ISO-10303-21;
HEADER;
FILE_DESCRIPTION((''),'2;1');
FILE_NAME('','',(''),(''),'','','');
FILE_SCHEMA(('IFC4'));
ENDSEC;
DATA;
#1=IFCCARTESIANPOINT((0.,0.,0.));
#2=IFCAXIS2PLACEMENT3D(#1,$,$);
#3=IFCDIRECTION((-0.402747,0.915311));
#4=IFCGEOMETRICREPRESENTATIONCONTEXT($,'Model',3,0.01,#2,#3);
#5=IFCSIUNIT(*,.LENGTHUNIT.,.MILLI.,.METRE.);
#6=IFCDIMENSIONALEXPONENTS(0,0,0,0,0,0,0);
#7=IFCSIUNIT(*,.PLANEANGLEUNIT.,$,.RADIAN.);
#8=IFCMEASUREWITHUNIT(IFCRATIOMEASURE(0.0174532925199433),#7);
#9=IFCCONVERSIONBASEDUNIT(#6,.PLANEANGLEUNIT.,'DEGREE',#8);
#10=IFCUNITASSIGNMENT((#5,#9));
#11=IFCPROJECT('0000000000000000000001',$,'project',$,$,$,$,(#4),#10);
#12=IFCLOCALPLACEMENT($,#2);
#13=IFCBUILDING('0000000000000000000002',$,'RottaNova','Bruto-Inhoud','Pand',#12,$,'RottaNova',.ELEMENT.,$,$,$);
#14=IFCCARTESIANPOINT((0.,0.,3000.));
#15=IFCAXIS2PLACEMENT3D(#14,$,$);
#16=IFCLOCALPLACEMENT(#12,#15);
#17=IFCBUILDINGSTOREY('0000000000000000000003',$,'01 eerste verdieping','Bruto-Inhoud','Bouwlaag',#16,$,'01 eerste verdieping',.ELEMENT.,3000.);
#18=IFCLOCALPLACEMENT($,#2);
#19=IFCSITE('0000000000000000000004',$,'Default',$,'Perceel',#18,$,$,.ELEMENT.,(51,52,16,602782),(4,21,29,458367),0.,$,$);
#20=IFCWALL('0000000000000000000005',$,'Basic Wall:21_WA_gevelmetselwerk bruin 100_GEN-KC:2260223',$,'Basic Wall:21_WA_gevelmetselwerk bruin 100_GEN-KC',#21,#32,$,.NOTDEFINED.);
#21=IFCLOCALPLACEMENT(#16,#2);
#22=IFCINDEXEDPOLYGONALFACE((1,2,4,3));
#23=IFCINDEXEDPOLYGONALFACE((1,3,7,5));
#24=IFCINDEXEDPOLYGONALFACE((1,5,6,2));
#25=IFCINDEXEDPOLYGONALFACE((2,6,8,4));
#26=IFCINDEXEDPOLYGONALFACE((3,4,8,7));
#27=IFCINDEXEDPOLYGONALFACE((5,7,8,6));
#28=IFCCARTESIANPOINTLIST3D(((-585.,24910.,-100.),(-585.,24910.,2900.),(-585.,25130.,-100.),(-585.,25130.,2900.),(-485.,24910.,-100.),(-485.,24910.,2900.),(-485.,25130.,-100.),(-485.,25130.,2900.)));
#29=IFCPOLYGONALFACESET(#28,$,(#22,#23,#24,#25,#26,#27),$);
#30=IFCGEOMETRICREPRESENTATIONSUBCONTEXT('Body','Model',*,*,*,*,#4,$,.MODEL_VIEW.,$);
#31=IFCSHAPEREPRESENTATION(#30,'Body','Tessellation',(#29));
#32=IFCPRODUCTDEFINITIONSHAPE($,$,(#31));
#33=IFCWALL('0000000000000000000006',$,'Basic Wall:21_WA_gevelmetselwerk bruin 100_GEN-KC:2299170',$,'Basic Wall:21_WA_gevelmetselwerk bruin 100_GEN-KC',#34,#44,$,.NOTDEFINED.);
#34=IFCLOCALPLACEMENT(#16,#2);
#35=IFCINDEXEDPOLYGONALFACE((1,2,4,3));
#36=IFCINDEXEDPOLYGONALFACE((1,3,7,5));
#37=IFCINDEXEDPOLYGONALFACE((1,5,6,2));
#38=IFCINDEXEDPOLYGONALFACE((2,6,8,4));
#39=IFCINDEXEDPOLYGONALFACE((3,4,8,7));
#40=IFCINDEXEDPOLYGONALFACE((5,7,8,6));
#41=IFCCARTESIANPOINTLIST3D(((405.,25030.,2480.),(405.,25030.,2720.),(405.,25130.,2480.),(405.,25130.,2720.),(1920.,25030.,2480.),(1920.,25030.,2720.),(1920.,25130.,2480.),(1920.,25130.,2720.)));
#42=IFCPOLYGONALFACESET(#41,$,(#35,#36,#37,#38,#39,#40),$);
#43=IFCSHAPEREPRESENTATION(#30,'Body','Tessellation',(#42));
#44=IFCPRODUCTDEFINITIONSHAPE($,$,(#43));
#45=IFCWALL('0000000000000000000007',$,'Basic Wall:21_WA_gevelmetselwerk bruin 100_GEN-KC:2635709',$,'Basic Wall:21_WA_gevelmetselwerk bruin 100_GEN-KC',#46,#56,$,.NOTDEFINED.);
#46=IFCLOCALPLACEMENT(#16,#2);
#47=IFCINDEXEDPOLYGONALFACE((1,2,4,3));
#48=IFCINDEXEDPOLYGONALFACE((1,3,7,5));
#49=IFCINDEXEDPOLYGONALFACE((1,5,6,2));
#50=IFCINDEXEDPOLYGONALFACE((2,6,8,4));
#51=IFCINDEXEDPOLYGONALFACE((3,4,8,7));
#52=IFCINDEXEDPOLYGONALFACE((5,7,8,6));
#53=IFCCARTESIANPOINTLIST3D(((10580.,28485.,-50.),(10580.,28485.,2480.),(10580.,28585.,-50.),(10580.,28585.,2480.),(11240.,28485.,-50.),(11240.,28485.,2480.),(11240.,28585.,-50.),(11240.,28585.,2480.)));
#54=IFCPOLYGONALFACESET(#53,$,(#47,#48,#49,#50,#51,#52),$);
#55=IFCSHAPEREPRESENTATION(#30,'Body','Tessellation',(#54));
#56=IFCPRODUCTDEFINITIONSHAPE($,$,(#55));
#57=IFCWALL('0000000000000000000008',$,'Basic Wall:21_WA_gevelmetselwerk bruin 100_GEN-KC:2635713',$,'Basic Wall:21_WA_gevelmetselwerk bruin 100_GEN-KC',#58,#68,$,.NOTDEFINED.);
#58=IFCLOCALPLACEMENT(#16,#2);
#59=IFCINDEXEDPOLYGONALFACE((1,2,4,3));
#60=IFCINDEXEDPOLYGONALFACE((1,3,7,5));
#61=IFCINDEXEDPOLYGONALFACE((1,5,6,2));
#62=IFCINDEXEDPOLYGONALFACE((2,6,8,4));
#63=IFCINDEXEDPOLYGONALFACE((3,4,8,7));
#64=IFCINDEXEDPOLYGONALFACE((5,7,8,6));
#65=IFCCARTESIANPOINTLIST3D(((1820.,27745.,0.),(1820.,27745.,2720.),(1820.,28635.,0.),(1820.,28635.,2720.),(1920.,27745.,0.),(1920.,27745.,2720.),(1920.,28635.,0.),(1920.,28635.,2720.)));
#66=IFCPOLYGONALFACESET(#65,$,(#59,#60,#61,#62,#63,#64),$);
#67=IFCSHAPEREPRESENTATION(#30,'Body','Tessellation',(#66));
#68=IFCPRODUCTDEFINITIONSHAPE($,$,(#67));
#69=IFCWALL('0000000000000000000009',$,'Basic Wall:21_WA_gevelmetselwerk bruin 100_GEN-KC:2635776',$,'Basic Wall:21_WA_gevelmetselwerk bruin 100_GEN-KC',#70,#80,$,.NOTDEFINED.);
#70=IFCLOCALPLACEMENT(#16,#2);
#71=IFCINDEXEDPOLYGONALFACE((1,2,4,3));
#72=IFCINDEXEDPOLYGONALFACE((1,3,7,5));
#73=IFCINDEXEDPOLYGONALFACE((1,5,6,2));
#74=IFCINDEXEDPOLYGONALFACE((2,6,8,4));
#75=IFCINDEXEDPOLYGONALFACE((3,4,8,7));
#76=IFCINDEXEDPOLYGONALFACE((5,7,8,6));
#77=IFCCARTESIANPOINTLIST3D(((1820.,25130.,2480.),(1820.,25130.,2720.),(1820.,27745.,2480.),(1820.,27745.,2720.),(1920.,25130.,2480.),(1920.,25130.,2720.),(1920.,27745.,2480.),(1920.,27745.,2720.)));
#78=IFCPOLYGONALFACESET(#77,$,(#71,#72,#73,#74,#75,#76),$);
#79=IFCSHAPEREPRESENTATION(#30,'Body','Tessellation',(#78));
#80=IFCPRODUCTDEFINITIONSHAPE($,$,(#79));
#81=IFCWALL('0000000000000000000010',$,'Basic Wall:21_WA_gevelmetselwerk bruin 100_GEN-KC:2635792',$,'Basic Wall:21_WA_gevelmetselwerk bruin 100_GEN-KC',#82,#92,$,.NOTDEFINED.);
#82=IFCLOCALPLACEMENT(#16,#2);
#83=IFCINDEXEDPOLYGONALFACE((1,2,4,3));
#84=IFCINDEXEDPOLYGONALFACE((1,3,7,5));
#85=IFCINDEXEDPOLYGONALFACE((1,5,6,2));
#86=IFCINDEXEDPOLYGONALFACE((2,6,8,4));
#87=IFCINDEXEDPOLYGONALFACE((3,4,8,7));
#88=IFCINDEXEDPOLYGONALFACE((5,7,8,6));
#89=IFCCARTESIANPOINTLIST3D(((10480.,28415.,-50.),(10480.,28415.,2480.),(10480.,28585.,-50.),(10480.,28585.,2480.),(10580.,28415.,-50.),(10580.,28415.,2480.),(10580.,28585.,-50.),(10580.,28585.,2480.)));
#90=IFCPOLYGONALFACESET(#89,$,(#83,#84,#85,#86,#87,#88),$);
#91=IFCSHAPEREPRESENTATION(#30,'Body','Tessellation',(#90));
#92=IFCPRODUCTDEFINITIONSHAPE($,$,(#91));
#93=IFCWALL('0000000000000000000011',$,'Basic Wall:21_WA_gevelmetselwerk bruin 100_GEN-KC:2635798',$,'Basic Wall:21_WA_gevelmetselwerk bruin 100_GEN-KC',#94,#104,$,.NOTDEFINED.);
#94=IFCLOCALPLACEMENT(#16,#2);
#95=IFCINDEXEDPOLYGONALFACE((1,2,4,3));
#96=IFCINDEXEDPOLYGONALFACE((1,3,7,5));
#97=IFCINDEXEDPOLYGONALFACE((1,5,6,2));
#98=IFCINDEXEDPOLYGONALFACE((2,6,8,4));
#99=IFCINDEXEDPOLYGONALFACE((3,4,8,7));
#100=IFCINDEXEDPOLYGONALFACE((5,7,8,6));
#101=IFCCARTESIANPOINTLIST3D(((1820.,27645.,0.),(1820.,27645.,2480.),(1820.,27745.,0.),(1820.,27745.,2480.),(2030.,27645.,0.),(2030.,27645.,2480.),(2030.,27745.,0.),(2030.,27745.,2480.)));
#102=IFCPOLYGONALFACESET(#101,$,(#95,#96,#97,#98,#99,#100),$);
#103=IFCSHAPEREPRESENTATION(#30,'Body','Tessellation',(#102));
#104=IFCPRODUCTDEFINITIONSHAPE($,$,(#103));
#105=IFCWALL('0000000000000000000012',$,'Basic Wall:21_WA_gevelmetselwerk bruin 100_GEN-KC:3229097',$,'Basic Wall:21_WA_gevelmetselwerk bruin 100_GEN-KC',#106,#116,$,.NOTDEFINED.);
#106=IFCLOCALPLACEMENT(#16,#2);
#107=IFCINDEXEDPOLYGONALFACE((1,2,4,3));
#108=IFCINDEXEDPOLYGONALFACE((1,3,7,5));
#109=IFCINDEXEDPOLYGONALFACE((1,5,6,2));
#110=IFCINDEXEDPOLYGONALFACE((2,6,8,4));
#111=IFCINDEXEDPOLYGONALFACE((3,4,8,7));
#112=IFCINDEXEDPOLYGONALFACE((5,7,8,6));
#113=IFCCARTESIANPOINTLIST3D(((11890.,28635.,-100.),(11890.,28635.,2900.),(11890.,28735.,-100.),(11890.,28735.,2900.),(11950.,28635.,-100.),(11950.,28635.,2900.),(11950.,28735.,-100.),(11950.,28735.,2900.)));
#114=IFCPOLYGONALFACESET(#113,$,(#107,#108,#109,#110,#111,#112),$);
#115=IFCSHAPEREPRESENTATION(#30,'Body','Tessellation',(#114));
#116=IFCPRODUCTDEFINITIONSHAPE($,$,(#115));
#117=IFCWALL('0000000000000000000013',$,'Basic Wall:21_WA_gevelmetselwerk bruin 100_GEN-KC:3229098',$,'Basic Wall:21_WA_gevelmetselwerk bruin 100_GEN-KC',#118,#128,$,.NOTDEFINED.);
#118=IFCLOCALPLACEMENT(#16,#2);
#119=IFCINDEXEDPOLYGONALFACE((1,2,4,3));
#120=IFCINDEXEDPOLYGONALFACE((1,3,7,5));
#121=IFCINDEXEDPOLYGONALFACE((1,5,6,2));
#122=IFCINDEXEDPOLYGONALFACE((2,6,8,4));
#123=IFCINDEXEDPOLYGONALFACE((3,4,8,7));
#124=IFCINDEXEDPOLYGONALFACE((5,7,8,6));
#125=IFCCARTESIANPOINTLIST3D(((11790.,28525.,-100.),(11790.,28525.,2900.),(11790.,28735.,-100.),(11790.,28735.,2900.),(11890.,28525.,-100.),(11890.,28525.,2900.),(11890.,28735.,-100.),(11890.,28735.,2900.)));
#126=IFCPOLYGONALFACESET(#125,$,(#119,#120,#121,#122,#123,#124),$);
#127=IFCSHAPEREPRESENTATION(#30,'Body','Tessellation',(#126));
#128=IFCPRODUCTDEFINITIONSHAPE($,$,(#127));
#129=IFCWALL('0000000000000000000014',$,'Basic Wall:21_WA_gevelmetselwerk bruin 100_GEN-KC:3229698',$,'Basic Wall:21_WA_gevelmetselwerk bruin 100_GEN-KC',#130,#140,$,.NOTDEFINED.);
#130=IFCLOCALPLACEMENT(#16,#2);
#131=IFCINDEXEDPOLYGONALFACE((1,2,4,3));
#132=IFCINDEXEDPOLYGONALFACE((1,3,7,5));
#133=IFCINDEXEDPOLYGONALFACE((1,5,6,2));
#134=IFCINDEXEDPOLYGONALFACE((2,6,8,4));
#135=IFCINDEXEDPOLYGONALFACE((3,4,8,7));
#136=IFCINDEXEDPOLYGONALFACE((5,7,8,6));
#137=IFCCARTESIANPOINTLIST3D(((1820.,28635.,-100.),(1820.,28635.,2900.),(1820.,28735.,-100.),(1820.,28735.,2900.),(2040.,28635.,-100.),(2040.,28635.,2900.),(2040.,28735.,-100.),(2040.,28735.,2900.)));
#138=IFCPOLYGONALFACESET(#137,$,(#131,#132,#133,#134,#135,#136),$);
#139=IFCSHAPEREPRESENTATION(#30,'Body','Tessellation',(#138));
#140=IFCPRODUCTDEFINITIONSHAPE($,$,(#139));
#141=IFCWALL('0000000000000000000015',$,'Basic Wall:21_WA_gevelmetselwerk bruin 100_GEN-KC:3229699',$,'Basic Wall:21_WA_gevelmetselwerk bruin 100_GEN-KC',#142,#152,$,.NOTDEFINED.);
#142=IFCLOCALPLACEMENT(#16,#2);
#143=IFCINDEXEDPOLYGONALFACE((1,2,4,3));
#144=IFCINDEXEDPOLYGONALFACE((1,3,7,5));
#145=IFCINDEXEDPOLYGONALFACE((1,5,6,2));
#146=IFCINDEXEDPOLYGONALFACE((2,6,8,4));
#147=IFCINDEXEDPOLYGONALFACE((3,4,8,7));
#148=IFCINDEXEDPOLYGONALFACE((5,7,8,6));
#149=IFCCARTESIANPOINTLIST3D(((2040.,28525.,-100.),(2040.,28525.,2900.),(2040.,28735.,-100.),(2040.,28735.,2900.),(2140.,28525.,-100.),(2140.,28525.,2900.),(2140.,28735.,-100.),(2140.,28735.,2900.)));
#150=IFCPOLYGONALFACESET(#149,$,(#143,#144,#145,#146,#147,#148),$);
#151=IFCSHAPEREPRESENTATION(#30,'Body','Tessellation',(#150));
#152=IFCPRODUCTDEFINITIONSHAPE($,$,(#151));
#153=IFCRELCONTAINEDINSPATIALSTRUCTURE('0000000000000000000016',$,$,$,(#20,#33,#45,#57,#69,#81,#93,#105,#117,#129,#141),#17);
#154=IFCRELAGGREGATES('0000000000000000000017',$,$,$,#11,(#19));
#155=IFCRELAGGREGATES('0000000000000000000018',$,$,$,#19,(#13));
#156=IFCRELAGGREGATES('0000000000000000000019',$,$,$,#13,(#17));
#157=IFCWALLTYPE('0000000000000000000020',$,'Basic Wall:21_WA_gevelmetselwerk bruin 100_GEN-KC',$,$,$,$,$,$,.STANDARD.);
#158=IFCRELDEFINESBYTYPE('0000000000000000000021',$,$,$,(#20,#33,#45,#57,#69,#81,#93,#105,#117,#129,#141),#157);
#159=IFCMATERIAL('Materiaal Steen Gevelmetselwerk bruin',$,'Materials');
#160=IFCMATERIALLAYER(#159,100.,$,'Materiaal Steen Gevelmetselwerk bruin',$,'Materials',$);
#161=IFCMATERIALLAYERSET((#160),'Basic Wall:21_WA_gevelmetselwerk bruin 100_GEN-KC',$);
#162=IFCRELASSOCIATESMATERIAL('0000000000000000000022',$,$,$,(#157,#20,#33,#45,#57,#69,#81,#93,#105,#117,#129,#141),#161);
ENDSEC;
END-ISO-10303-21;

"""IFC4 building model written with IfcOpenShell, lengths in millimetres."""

from ifc_helpers import new_model, entity, si_unit, converted_unit, direction, frame, frame_2d, origin, place, context, subcontext, project, spatial, rectangle, extrude, material, layer, layer_set, type_object, element, save


model = new_model("IFC4")

# Units and contexts
model_context = context("Model", 3, precision=0.01, world=origin(), true_north=direction((-0.402747, 0.915311)))
body_context = subcontext(model_context, "Body", "Model", "MODEL_VIEW")
ifc_project = project(units=[si_unit("LENGTHUNIT", "METRE", prefix="MILLI"), converted_unit("PLANEANGLEUNIT", "DEGREE", entity("IfcRatioMeasure", 0.0174532925199433), si_unit("PLANEANGLEUNIT", "RADIAN"), dimensions=[0, 0, 0, 0, 0, 0, 0])], contexts=[model_context])

# Site, building, storey
site_placement = place(None, origin())
site = spatial("IfcSite", under=ifc_project, at=site_placement, Name="Default", ObjectType="Perceel", CompositionType="ELEMENT", RefLatitude=(51, 52, 16, 602782), RefLongitude=(4, 21, 29, 458367), RefElevation=0.0)
building_placement = place(None, origin())
building = spatial("IfcBuilding", under=site, at=building_placement, Name="RottaNova", Description="Bruto-Inhoud", ObjectType="Pand", LongName="RottaNova", CompositionType="ELEMENT")
storey_placement = place(building_placement, frame((0.0, 0.0, 3000.0)))
storey = spatial("IfcBuildingStorey", under=building, at=storey_placement, Name="01 eerste verdieping", Description="Bruto-Inhoud", ObjectType="Bouwlaag", LongName="01 eerste verdieping", CompositionType="ELEMENT", Elevation=3000.0)

# Walls
ifc_material_1 = material(Name="Materiaal Steen Gevelmetselwerk bruin", Category="Materials")
ifc_layer_1 = layer(ifc_material_1, 100.0, Name="Materiaal Steen Gevelmetselwerk bruin", Category="Materials")
ifc_layer_set_1 = layer_set([ifc_layer_1], Name="Basic Wall:21_WA_gevelmetselwerk bruin 100_GEN-KC")
wall_type_1 = type_object("IfcWallType", Name="Basic Wall:21_WA_gevelmetselwerk bruin 100_GEN-KC", PredefinedType="STANDARD", material=ifc_layer_set_1)
wall_1_placement = place(storey_placement, frame((-535.0, 25130.0, -100.0), z_axis=(0.0, 0.0, 1.0), x_axis=(0.0, -1.0, 0.0)))
element("IfcWall", 1, at=wall_1_placement, inside=storey, type_object=wall_type_1, material=ifc_layer_set_1, Name="Basic Wall:21_WA_gevelmetselwerk bruin 100_GEN-KC:2260223", ObjectType="Basic Wall:21_WA_gevelmetselwerk bruin 100_GEN-KC", PredefinedType="NOTDEFINED", context=body_context, shape_type="SweptSolid", body=[
    extrude(rectangle(XDim=220.0, YDim=100.0, at=frame_2d((110.0, 0.0), x_axis=(-1.0, 0.0))), origin(), (0.0, 0.0, 1.0), 3000.0),
])
wall_2_placement = place(storey_placement, frame((405.0, 25080.0, 2480.0)))
element("IfcWall", 2, at=wall_2_placement, inside=storey, type_object=wall_type_1, material=ifc_layer_set_1, Name="Basic Wall:21_WA_gevelmetselwerk bruin 100_GEN-KC:2299170", ObjectType="Basic Wall:21_WA_gevelmetselwerk bruin 100_GEN-KC", PredefinedType="NOTDEFINED", context=body_context, shape_type="SweptSolid", body=[
    extrude(rectangle(XDim=1515.0, YDim=100.0, at=frame_2d((757.5, 0.0), x_axis=(-1.0, 0.0))), origin(), (0.0, 0.0, 1.0), 240.0),
])
wall_3_placement = place(storey_placement, frame((11240.0, 28535.0, -50.0), z_axis=(0.0, 0.0, 1.0), x_axis=(-1.0, 0.0, 0.0)))
element("IfcWall", 3, at=wall_3_placement, inside=storey, type_object=wall_type_1, material=ifc_layer_set_1, Name="Basic Wall:21_WA_gevelmetselwerk bruin 100_GEN-KC:2635709", ObjectType="Basic Wall:21_WA_gevelmetselwerk bruin 100_GEN-KC", PredefinedType="NOTDEFINED", context=body_context, shape_type="SweptSolid", body=[
    extrude(rectangle(XDim=660.0, YDim=100.0, at=frame_2d((330.0, 0.0), x_axis=(-1.0, 0.0))), origin(), (0.0, 0.0, 1.0), 2530.0),
])
wall_4_placement = place(storey_placement, frame((1870.0, 27745.0, 0.0), z_axis=(0.0, 0.0, 1.0), x_axis=(0.0, 1.0, 0.0)))
element("IfcWall", 4, at=wall_4_placement, inside=storey, type_object=wall_type_1, material=ifc_layer_set_1, Name="Basic Wall:21_WA_gevelmetselwerk bruin 100_GEN-KC:2635713", ObjectType="Basic Wall:21_WA_gevelmetselwerk bruin 100_GEN-KC", PredefinedType="NOTDEFINED", context=body_context, shape_type="SweptSolid", body=[
    extrude(rectangle(XDim=890.0, YDim=100.0, at=frame_2d((445.0, 0.0), x_axis=(-1.0, 0.0))), origin(), (0.0, 0.0, 1.0), 2720.0),
])
wall_5_placement = place(storey_placement, frame((1870.0, 25130.0, 2480.0), z_axis=(0.0, 0.0, 1.0), x_axis=(0.0, 1.0, 0.0)))
element("IfcWall", 5, at=wall_5_placement, inside=storey, type_object=wall_type_1, material=ifc_layer_set_1, Name="Basic Wall:21_WA_gevelmetselwerk bruin 100_GEN-KC:2635776", ObjectType="Basic Wall:21_WA_gevelmetselwerk bruin 100_GEN-KC", PredefinedType="NOTDEFINED", context=body_context, shape_type="SweptSolid", body=[
    extrude(rectangle(XDim=2615.0, YDim=100.0, at=frame_2d((1307.5, 0.0), x_axis=(-1.0, 0.0))), origin(), (0.0, 0.0, 1.0), 240.0),
])
wall_6_placement = place(storey_placement, frame((10530.0, 28415.0, -50.0), z_axis=(0.0, 0.0, 1.0), x_axis=(0.0, 1.0, 0.0)))
element("IfcWall", 6, at=wall_6_placement, inside=storey, type_object=wall_type_1, material=ifc_layer_set_1, Name="Basic Wall:21_WA_gevelmetselwerk bruin 100_GEN-KC:2635792", ObjectType="Basic Wall:21_WA_gevelmetselwerk bruin 100_GEN-KC", PredefinedType="NOTDEFINED", context=body_context, shape_type="SweptSolid", body=[
    extrude(rectangle(XDim=170.0, YDim=100.0, at=frame_2d((85.0, 0.0), x_axis=(-1.0, 0.0))), origin(), (0.0, 0.0, 1.0), 2530.0),
])
wall_7_placement = place(storey_placement, frame((2030.0, 27695.0, 0.0), z_axis=(0.0, 0.0, 1.0), x_axis=(-1.0, 0.0, 0.0)))
element("IfcWall", 7, at=wall_7_placement, inside=storey, type_object=wall_type_1, material=ifc_layer_set_1, Name="Basic Wall:21_WA_gevelmetselwerk bruin 100_GEN-KC:2635798", ObjectType="Basic Wall:21_WA_gevelmetselwerk bruin 100_GEN-KC", PredefinedType="NOTDEFINED", context=body_context, shape_type="SweptSolid", body=[
    extrude(rectangle(XDim=210.0, YDim=100.0, at=frame_2d((105.0, 0.0), x_axis=(-1.0, 0.0))), origin(), (0.0, 0.0, 1.0), 2480.0),
])
wall_8_placement = place(storey_placement, frame((11890.0, 28685.0, -100.0)))
element("IfcWall", 8, at=wall_8_placement, inside=storey, type_object=wall_type_1, material=ifc_layer_set_1, Name="Basic Wall:21_WA_gevelmetselwerk bruin 100_GEN-KC:3229097", ObjectType="Basic Wall:21_WA_gevelmetselwerk bruin 100_GEN-KC", PredefinedType="NOTDEFINED", context=body_context, shape_type="SweptSolid", body=[
    extrude(rectangle(XDim=60.0, YDim=100.0, at=frame_2d((30.0, 0.0), x_axis=(-1.0, 0.0))), origin(), (0.0, 0.0, 1.0), 3000.0),
])
wall_9_placement = place(storey_placement, frame((11840.0, 28735.0, -100.0), z_axis=(0.0, 0.0, 1.0), x_axis=(0.0, -1.0, 0.0)))
element("IfcWall", 9, at=wall_9_placement, inside=storey, type_object=wall_type_1, material=ifc_layer_set_1, Name="Basic Wall:21_WA_gevelmetselwerk bruin 100_GEN-KC:3229098", ObjectType="Basic Wall:21_WA_gevelmetselwerk bruin 100_GEN-KC", PredefinedType="NOTDEFINED", context=body_context, shape_type="SweptSolid", body=[
    extrude(rectangle(XDim=210.0, YDim=100.0, at=frame_2d((105.0, 0.0), x_axis=(-1.0, 0.0))), origin(), (0.0, 0.0, 1.0), 3000.0),
])
wall_10_placement = place(storey_placement, frame((2040.0, 28685.0, -100.0), z_axis=(0.0, 0.0, 1.0), x_axis=(-1.0, 0.0, 0.0)))
element("IfcWall", 10, at=wall_10_placement, inside=storey, type_object=wall_type_1, material=ifc_layer_set_1, Name="Basic Wall:21_WA_gevelmetselwerk bruin 100_GEN-KC:3229698", ObjectType="Basic Wall:21_WA_gevelmetselwerk bruin 100_GEN-KC", PredefinedType="NOTDEFINED", context=body_context, shape_type="SweptSolid", body=[
    extrude(rectangle(XDim=220.0, YDim=100.0, at=frame_2d((110.0, 0.0), x_axis=(-1.0, 0.0))), origin(), (0.0, 0.0, 1.0), 3000.0),
])
wall_11_placement = place(storey_placement, frame((2090.0, 28735.0, -100.0), z_axis=(0.0, 0.0, 1.0), x_axis=(0.0, -1.0, 0.0)))
element("IfcWall", 11, at=wall_11_placement, inside=storey, type_object=wall_type_1, material=ifc_layer_set_1, Name="Basic Wall:21_WA_gevelmetselwerk bruin 100_GEN-KC:3229699", ObjectType="Basic Wall:21_WA_gevelmetselwerk bruin 100_GEN-KC", PredefinedType="NOTDEFINED", context=body_context, shape_type="SweptSolid", body=[
    extrude(rectangle(XDim=210.0, YDim=100.0, at=frame_2d((105.0, 0.0), x_axis=(-1.0, 0.0))), origin(), (0.0, 0.0, 1.0), 3000.0),
])

save(model, "model.ifc")
